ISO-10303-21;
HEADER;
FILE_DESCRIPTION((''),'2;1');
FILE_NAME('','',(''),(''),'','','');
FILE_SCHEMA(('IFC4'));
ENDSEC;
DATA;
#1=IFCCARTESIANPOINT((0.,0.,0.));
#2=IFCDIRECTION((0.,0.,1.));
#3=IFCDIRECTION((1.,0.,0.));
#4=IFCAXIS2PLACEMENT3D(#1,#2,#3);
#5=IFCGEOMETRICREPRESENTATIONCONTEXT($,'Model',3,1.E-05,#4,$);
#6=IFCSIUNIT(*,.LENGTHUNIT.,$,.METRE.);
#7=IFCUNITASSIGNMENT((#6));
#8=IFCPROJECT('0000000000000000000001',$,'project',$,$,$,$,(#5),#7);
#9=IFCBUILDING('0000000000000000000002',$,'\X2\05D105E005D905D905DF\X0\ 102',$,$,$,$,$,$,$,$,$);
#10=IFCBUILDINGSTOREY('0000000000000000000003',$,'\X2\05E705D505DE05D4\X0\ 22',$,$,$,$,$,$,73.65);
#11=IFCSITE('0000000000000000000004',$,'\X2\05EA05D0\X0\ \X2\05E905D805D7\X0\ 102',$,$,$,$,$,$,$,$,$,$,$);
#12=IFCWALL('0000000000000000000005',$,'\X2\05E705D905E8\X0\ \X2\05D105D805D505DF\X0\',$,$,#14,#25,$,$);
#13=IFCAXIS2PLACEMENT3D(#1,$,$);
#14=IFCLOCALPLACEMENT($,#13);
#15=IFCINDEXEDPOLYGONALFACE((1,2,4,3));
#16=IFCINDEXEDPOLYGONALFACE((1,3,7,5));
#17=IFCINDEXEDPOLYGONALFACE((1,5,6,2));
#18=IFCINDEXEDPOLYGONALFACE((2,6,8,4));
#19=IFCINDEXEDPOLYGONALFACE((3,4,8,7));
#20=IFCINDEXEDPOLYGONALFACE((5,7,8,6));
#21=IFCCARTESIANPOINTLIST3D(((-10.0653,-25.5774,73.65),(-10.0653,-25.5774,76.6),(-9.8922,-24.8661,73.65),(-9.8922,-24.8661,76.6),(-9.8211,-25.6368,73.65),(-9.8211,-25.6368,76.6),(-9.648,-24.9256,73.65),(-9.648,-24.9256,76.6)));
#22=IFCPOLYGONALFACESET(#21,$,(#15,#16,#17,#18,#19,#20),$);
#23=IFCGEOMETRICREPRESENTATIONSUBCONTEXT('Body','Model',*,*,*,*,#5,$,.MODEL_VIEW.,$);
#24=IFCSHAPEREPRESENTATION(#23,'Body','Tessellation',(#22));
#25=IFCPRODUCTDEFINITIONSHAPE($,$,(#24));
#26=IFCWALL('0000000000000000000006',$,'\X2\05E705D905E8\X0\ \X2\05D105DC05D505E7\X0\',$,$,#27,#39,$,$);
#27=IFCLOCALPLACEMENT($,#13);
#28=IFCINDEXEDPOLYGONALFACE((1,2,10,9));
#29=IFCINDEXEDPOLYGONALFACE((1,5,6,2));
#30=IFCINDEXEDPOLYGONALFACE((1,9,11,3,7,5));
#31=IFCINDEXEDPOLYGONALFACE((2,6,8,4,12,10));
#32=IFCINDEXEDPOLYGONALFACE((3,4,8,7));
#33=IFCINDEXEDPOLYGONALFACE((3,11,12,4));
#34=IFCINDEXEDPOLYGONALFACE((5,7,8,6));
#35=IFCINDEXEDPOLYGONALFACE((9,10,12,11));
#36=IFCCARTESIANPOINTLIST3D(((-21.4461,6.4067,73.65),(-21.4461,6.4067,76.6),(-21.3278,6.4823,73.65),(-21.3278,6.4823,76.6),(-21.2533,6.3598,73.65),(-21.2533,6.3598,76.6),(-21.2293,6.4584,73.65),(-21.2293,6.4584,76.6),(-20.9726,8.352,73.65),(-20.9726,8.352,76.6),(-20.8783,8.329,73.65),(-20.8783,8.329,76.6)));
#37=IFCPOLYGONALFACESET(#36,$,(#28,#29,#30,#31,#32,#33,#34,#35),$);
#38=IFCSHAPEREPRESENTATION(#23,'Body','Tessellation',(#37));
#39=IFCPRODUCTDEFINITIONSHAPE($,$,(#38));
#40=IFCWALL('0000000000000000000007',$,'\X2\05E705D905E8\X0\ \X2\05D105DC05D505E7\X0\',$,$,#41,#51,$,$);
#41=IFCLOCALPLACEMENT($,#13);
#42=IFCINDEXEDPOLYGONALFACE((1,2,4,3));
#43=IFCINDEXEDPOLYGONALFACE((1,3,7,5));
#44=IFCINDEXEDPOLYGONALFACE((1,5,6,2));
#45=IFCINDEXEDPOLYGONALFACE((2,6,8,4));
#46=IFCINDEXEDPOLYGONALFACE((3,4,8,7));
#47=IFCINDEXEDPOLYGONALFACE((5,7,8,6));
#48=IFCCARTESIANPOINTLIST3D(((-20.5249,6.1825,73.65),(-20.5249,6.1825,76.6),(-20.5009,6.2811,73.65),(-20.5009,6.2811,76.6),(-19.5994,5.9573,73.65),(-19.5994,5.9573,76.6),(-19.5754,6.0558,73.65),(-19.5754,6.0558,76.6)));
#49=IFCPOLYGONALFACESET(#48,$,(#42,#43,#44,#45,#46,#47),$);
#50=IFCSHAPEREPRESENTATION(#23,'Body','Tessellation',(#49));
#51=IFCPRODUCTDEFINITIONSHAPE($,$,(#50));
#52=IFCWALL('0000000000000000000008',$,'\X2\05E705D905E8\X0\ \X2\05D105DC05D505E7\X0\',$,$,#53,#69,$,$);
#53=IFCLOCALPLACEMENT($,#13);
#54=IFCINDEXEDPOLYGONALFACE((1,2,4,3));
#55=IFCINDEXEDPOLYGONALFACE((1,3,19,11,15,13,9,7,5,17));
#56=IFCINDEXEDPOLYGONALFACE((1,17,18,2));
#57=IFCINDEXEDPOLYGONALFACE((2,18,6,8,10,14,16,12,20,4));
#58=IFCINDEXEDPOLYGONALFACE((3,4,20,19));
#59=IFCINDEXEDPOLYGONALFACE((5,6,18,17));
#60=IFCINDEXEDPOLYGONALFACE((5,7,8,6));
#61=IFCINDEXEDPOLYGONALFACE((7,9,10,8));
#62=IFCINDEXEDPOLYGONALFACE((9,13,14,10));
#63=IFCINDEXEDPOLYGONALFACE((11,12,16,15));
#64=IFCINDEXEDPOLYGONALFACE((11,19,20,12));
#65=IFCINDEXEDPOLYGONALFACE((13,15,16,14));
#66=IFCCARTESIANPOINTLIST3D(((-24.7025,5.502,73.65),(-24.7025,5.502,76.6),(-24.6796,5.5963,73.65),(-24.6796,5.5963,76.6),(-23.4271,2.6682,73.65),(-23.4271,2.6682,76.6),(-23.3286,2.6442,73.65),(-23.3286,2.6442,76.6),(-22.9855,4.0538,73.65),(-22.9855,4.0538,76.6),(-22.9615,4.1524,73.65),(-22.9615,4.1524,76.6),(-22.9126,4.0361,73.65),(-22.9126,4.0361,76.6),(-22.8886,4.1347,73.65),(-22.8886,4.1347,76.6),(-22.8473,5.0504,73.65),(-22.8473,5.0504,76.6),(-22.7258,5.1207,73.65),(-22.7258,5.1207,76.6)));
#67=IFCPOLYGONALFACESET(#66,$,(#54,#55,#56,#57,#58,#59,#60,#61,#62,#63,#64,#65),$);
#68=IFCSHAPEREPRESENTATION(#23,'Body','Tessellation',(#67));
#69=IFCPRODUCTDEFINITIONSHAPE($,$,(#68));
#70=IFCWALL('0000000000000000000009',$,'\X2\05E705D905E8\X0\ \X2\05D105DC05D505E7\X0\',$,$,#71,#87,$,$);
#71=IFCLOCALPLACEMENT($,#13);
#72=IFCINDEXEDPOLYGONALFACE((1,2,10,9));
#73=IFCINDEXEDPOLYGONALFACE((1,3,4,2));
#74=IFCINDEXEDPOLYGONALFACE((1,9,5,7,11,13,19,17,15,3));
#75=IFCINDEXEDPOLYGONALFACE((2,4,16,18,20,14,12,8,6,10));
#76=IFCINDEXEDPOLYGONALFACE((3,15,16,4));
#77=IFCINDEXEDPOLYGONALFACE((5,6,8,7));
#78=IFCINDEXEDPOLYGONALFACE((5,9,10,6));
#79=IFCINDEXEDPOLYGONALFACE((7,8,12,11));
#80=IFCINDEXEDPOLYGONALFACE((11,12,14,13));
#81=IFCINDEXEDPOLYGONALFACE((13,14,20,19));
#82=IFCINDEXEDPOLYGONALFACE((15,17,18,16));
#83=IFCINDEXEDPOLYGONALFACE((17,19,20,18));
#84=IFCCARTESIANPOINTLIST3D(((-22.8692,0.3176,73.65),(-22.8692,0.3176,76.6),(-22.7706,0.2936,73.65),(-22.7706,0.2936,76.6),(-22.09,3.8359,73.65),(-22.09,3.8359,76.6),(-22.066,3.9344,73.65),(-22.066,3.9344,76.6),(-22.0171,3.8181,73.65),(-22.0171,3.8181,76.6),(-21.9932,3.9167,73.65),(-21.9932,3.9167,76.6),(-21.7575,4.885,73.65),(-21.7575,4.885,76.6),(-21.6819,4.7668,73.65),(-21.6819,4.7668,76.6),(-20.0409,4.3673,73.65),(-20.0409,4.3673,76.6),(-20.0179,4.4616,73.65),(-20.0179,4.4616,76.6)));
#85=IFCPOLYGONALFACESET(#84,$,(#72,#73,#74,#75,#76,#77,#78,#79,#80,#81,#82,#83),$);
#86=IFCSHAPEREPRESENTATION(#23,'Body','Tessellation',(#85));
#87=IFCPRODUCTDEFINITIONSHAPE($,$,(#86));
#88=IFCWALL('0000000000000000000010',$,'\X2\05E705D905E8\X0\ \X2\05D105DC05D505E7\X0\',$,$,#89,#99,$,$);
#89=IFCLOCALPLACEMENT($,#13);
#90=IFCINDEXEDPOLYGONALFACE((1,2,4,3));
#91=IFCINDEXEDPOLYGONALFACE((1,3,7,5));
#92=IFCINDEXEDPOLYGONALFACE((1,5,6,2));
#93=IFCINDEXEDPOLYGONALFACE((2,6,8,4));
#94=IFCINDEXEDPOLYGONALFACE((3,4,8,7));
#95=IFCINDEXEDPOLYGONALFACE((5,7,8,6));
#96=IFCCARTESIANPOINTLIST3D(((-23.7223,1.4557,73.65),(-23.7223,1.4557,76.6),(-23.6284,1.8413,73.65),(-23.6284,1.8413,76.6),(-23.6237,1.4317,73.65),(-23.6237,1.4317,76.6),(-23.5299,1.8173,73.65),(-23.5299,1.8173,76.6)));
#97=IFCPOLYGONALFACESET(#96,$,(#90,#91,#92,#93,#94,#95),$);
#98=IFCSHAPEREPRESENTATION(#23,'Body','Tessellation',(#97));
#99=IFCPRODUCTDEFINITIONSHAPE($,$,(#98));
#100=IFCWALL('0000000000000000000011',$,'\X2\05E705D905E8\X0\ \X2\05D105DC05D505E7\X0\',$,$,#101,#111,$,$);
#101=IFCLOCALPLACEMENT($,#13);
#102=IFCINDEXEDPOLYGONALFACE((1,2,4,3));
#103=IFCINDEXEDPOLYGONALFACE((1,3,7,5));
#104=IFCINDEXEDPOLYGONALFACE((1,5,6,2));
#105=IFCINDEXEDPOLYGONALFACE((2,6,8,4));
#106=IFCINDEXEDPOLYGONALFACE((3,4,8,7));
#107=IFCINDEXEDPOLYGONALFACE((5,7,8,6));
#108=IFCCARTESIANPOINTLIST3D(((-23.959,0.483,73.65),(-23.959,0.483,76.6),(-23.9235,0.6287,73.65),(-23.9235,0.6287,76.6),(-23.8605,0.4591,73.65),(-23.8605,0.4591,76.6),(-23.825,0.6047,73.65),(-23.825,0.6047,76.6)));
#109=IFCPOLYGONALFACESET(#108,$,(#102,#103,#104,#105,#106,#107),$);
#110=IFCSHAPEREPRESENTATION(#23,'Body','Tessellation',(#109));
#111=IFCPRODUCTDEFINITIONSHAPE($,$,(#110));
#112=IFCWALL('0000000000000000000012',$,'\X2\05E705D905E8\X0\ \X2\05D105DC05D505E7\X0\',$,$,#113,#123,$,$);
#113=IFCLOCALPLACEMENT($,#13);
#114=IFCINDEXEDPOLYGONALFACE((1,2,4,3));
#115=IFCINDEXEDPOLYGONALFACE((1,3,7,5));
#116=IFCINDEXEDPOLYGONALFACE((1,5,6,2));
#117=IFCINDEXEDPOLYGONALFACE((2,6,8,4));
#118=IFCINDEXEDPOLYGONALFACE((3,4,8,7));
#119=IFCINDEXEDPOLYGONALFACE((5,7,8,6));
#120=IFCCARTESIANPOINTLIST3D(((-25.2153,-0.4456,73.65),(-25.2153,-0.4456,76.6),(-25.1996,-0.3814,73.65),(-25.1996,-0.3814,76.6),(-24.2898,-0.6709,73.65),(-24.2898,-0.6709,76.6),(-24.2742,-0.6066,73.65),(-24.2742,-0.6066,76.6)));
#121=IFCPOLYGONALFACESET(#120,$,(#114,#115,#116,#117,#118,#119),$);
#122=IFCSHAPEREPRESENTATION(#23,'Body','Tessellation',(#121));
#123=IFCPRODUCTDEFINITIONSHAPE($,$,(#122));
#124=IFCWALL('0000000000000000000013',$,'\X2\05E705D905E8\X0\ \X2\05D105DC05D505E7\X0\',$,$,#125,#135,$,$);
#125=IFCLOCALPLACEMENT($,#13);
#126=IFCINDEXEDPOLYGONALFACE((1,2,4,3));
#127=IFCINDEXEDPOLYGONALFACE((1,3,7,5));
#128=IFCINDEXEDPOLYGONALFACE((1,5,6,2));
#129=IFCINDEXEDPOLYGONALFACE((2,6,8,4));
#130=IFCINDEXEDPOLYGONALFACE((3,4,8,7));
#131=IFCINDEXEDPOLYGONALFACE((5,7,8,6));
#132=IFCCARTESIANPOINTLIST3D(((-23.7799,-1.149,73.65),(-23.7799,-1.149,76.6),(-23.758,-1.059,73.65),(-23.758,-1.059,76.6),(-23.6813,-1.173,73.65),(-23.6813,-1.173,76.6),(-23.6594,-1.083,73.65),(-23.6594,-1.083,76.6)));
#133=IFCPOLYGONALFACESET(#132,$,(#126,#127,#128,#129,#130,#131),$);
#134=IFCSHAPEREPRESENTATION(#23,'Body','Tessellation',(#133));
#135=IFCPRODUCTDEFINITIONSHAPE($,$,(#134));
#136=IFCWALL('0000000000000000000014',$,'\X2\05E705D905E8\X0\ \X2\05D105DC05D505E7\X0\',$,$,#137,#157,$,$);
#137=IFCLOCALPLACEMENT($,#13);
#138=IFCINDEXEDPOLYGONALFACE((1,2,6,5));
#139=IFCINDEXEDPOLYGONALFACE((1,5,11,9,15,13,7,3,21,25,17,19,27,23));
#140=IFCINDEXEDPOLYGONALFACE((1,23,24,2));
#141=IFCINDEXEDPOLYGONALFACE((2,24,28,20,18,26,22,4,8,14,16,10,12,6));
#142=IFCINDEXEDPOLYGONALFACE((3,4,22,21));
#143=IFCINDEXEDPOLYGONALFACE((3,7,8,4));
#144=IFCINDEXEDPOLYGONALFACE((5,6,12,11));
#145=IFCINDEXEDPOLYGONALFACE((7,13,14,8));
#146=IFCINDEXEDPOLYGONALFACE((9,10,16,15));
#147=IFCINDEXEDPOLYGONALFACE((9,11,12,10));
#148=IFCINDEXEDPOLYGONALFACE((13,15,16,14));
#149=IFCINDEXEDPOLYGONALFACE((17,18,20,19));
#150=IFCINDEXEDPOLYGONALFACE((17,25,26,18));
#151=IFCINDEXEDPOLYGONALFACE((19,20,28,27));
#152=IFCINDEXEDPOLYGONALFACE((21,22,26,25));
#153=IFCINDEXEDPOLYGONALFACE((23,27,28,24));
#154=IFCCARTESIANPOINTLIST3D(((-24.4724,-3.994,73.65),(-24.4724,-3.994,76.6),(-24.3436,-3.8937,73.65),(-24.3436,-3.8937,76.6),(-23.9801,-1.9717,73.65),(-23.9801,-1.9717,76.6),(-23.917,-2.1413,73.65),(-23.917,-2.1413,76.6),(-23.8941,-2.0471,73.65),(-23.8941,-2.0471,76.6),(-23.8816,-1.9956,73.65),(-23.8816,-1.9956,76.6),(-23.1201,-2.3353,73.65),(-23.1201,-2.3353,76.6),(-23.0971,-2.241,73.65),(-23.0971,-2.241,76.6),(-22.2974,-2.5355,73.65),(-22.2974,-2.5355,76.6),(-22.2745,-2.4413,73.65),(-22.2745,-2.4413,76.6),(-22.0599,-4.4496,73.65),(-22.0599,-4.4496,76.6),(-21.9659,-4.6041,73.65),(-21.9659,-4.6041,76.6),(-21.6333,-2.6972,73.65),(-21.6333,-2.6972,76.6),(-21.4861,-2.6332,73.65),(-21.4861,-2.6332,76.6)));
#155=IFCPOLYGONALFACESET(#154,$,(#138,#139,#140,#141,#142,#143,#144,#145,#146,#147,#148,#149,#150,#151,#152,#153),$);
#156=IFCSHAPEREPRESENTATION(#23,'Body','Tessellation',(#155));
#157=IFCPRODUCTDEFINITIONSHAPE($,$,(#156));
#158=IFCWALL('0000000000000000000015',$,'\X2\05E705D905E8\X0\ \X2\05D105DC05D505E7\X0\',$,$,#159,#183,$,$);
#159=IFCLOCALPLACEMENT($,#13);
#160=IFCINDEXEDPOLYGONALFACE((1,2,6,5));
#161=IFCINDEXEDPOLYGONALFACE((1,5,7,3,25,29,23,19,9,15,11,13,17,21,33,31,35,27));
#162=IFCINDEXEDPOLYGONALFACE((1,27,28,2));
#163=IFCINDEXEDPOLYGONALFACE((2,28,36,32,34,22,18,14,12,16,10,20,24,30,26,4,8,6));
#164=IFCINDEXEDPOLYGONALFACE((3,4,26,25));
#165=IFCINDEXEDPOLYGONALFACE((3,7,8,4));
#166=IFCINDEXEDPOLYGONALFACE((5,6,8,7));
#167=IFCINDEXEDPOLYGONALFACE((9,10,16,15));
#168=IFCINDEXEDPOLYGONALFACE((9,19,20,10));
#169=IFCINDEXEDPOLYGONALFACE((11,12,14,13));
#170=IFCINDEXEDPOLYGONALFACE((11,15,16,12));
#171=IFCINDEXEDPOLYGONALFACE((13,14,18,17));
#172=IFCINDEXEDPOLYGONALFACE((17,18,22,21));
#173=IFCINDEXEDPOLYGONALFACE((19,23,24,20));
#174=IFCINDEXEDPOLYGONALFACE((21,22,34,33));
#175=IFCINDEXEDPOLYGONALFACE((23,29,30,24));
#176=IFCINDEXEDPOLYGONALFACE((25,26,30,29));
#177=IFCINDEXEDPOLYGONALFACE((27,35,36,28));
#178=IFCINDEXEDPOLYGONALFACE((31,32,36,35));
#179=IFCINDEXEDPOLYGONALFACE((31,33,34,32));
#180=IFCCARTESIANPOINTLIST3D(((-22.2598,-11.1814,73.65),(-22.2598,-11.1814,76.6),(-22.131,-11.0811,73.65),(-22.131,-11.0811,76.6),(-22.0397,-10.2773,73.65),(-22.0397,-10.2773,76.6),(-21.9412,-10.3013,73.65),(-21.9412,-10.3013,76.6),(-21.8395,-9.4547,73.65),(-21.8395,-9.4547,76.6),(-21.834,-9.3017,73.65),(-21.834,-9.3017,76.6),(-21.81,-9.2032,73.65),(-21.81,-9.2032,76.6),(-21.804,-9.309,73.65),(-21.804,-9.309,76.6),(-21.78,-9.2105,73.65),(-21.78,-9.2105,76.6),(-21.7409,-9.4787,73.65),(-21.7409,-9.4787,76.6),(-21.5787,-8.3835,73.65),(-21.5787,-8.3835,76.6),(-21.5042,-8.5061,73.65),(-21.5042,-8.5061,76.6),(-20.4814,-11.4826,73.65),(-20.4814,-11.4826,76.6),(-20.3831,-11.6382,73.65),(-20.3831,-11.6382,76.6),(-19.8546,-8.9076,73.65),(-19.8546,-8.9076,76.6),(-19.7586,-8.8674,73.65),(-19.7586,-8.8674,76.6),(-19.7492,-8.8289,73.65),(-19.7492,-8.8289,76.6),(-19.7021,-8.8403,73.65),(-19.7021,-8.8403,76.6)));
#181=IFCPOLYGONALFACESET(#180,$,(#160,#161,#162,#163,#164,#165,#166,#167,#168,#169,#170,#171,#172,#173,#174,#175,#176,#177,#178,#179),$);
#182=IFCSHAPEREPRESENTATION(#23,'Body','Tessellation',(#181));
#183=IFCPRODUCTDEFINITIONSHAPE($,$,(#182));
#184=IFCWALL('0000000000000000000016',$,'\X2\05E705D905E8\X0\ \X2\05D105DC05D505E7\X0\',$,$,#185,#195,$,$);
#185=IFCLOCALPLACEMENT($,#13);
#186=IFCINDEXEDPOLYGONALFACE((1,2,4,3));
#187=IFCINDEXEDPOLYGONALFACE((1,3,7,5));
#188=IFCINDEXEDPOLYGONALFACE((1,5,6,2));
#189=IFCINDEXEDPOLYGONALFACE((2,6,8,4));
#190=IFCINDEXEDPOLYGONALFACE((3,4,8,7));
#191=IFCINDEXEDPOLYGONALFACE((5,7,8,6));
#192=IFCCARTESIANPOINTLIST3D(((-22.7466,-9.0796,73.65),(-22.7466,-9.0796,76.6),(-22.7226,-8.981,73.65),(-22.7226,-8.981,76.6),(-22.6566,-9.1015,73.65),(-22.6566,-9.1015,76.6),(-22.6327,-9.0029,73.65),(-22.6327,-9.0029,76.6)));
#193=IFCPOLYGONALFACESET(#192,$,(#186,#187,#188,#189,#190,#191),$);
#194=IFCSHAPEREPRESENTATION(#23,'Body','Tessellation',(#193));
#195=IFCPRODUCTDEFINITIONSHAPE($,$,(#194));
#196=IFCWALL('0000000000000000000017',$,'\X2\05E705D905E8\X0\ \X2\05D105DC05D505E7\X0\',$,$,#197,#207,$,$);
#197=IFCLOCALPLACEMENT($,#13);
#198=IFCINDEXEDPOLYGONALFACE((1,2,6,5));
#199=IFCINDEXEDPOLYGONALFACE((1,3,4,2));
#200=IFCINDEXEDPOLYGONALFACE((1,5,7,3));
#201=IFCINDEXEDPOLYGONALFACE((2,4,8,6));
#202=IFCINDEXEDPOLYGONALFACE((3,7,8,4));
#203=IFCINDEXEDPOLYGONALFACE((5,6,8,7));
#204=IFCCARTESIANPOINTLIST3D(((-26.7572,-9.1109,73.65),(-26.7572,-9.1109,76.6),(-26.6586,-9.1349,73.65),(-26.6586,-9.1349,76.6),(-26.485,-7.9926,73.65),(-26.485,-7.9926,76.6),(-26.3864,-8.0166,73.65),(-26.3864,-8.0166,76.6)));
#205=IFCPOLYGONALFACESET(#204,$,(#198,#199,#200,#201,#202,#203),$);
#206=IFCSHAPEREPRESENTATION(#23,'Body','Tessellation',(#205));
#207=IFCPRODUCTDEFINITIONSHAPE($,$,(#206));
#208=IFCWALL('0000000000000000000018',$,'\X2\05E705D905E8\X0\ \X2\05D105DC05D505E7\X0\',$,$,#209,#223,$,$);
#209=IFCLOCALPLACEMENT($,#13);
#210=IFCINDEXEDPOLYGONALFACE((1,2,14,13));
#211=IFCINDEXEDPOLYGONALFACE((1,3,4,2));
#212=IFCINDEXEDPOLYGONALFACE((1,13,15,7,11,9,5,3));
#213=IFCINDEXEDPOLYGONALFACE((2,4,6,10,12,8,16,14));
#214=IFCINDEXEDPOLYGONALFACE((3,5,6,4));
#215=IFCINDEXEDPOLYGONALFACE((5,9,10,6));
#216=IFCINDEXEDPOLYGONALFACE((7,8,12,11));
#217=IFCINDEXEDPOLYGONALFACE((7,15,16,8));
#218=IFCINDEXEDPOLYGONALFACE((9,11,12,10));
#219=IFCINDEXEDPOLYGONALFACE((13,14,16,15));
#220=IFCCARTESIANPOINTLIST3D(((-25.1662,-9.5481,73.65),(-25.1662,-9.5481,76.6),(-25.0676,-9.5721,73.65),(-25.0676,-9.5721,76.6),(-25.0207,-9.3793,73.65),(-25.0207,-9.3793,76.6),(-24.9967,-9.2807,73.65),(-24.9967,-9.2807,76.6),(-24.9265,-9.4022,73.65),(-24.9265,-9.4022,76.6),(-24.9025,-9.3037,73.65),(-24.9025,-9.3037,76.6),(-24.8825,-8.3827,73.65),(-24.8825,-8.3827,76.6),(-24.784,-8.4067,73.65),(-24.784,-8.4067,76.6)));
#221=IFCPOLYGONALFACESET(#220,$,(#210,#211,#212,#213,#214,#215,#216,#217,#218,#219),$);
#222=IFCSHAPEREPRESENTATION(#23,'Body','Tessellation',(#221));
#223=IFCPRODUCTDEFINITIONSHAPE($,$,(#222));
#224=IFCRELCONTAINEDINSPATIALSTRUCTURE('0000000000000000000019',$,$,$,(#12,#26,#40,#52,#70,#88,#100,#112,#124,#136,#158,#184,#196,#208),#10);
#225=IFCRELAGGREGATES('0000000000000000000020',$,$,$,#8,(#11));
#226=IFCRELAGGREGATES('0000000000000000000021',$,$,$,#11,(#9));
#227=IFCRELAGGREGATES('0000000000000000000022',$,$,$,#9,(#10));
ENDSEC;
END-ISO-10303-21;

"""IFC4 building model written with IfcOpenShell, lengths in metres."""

from ifc_helpers import new_model, si_unit, frame, origin_with_axes, context, subcontext, project, spatial, polyline, outline, extrude, element, save


model = new_model("IFC4")

# Units and contexts
model_context = context("Model", 3, precision=1e-05, world=origin_with_axes())
body_context = subcontext(model_context, "Body", "Model", "MODEL_VIEW")
ifc_project = project(units=[si_unit("LENGTHUNIT", "METRE")], contexts=[model_context])

# Site, building, storey
site = spatial("IfcSite", under=ifc_project, Name="תא שטח 102")
building = spatial("IfcBuilding", under=site, Name="בניין 102")
storey = spatial("IfcBuildingStorey", under=building, Name="קומה 22", Elevation=73.65)

# Walls
element("IfcWall", 1, inside=storey, Name="קיר בטון", context=body_context, shape_type="SweptSolid", body=[
    extrude(outline(polyline([(-10.0653, -25.5774), (-9.8211, -25.6368), (-9.648, -24.9256), (-9.8922, -24.8661), (-10.0653, -25.5774)])), frame((0.0, 0.0, 73.65)), (0.0, 0.0, 1.0), 2.95),
])
element("IfcWall", 2, inside=storey, Name="קיר בלוק", context=body_context, shape_type="SweptSolid", body=[
    extrude(outline(polyline([(-21.4461, 6.4067), (-21.2533, 6.3598), (-21.2293, 6.4584), (-21.3278, 6.4823), (-20.8783, 8.329), (-20.9726, 8.352), (-21.4461, 6.4067)])), frame((0.0, 0.0, 73.65)), (0.0, 0.0, 1.0), 2.95),
])
element("IfcWall", 3, inside=storey, Name="קיר בלוק", context=body_context, shape_type="SweptSolid", body=[
    extrude(outline(polyline([(-19.5754, 6.0558), (-20.5009, 6.2811), (-20.5249, 6.1825), (-19.5994, 5.9573), (-19.5754, 6.0558)])), frame((0.0, 0.0, 73.65)), (0.0, 0.0, 1.0), 2.95),
])
element("IfcWall", 4, inside=storey, Name="קיר בלוק", context=body_context, shape_type="SweptSolid", body=[
    extrude(outline(polyline([(-23.4271, 2.6682), (-23.3286, 2.6442), (-22.9855, 4.0538), (-22.9126, 4.0361), (-22.8886, 4.1347), (-22.9615, 4.1524), (-22.7258, 5.1207), (-24.6796, 5.5963), (-24.7025, 5.502), (-22.8473, 5.0504), (-23.4271, 2.6682)])), frame((0.0, 0.0, 73.65)), (0.0, 0.0, 1.0), 2.95),
])
element("IfcWall", 5, inside=storey, Name="קיר בלוק", context=body_context, shape_type="SweptSolid", body=[
    extrude(outline(polyline([(-22.09, 3.8359), (-22.0171, 3.8181), (-22.8692, 0.3176), (-22.7706, 0.2936), (-21.6819, 4.7668), (-20.0409, 4.3673), (-20.0179, 4.4616), (-21.7575, 4.885), (-21.9932, 3.9167), (-22.066, 3.9344), (-22.09, 3.8359)])), frame((0.0, 0.0, 73.65)), (0.0, 0.0, 1.0), 2.95),
])
element("IfcWall", 6, inside=storey, Name="קיר בלוק", context=body_context, shape_type="SweptSolid", body=[
    extrude(outline(polyline([(-23.5299, 1.8173), (-23.6284, 1.8413), (-23.7223, 1.4557), (-23.6237, 1.4317), (-23.5299, 1.8173)])), frame((0.0, 0.0, 73.65)), (0.0, 0.0, 1.0), 2.95),
])
element("IfcWall", 7, inside=storey, Name="קיר בלוק", context=body_context, shape_type="SweptSolid", body=[
    extrude(outline(polyline([(-23.9235, 0.6287), (-23.959, 0.483), (-23.8605, 0.4591), (-23.825, 0.6047), (-23.9235, 0.6287)])), frame((0.0, 0.0, 73.65)), (0.0, 0.0, 1.0), 2.95),
])
element("IfcWall", 8, inside=storey, Name="קיר בלוק", context=body_context, shape_type="SweptSolid", body=[
    extrude(outline(polyline([(-25.1996, -0.3814), (-25.2153, -0.4456), (-24.2898, -0.6709), (-24.2742, -0.6066), (-25.1996, -0.3814)])), frame((0.0, 0.0, 73.65)), (0.0, 0.0, 1.0), 2.95),
])
element("IfcWall", 9, inside=storey, Name="קיר בלוק", context=body_context, shape_type="SweptSolid", body=[
    extrude(outline(polyline([(-23.6594, -1.083), (-23.758, -1.059), (-23.7799, -1.149), (-23.6813, -1.173), (-23.6594, -1.083)])), frame((0.0, 0.0, 73.65)), (0.0, 0.0, 1.0), 2.95),
])
element("IfcWall", 10, inside=storey, Name="קיר בלוק", context=body_context, shape_type="SweptSolid", body=[
    extrude(outline(polyline([(-24.3436, -3.8937), (-23.917, -2.1413), (-23.1201, -2.3353), (-23.0971, -2.241), (-23.8941, -2.0471), (-23.8816, -1.9956), (-23.9801, -1.9717), (-24.4724, -3.994), (-21.9659, -4.6041), (-21.4861, -2.6332), (-22.2745, -2.4413), (-22.2974, -2.5355), (-21.6333, -2.6972), (-22.0599, -4.4496), (-24.3436, -3.8937)])), frame((0.0, 0.0, 73.65)), (0.0, 0.0, 1.0), 2.95),
])
element("IfcWall", 11, inside=storey, Name="קיר בלוק", context=body_context, shape_type="SweptSolid", body=[
    extrude(outline(polyline([(-21.81, -9.2032), (-21.834, -9.3017), (-21.804, -9.309), (-21.8395, -9.4547), (-21.7409, -9.4787), (-21.5042, -8.5061), (-19.8546, -8.9076), (-20.4814, -11.4826), (-22.131, -11.0811), (-21.9412, -10.3013), (-22.0397, -10.2773), (-22.2598, -11.1814), (-20.3831, -11.6382), (-19.7021, -8.8403), (-19.7586, -8.8674), (-19.7492, -8.8289), (-21.5787, -8.3835), (-21.78, -9.2105), (-21.81, -9.2032)])), frame((0.0, 0.0, 73.65)), (0.0, 0.0, 1.0), 2.95),
])
element("IfcWall", 12, inside=storey, Name="קיר בלוק", context=body_context, shape_type="SweptSolid", body=[
    extrude(outline(polyline([(-22.7226, -8.981), (-22.7466, -9.0796), (-22.6566, -9.1015), (-22.6327, -9.0029), (-22.7226, -8.981)])), frame((0.0, 0.0, 73.65)), (0.0, 0.0, 1.0), 2.95),
])
element("IfcWall", 13, inside=storey, Name="קיר בלוק", context=body_context, shape_type="SweptSolid", body=[
    extrude(outline(polyline([(-26.7572, -9.1109), (-26.6586, -9.1349), (-26.3864, -8.0166), (-26.485, -7.9926), (-26.7572, -9.1109)])), frame((0.0, 0.0, 73.65)), (0.0, 0.0, 1.0), 2.95),
])
element("IfcWall", 14, inside=storey, Name="קיר בלוק", context=body_context, shape_type="SweptSolid", body=[
    extrude(outline(polyline([(-24.9025, -9.3037), (-24.9967, -9.2807), (-24.784, -8.4067), (-24.8825, -8.3827), (-25.1662, -9.5481), (-25.0676, -9.5721), (-25.0207, -9.3793), (-24.9265, -9.4022), (-24.9025, -9.3037)])), frame((0.0, 0.0, 73.65)), (0.0, 0.0, 1.0), 2.95),
])

save(model, "model.ifc")
